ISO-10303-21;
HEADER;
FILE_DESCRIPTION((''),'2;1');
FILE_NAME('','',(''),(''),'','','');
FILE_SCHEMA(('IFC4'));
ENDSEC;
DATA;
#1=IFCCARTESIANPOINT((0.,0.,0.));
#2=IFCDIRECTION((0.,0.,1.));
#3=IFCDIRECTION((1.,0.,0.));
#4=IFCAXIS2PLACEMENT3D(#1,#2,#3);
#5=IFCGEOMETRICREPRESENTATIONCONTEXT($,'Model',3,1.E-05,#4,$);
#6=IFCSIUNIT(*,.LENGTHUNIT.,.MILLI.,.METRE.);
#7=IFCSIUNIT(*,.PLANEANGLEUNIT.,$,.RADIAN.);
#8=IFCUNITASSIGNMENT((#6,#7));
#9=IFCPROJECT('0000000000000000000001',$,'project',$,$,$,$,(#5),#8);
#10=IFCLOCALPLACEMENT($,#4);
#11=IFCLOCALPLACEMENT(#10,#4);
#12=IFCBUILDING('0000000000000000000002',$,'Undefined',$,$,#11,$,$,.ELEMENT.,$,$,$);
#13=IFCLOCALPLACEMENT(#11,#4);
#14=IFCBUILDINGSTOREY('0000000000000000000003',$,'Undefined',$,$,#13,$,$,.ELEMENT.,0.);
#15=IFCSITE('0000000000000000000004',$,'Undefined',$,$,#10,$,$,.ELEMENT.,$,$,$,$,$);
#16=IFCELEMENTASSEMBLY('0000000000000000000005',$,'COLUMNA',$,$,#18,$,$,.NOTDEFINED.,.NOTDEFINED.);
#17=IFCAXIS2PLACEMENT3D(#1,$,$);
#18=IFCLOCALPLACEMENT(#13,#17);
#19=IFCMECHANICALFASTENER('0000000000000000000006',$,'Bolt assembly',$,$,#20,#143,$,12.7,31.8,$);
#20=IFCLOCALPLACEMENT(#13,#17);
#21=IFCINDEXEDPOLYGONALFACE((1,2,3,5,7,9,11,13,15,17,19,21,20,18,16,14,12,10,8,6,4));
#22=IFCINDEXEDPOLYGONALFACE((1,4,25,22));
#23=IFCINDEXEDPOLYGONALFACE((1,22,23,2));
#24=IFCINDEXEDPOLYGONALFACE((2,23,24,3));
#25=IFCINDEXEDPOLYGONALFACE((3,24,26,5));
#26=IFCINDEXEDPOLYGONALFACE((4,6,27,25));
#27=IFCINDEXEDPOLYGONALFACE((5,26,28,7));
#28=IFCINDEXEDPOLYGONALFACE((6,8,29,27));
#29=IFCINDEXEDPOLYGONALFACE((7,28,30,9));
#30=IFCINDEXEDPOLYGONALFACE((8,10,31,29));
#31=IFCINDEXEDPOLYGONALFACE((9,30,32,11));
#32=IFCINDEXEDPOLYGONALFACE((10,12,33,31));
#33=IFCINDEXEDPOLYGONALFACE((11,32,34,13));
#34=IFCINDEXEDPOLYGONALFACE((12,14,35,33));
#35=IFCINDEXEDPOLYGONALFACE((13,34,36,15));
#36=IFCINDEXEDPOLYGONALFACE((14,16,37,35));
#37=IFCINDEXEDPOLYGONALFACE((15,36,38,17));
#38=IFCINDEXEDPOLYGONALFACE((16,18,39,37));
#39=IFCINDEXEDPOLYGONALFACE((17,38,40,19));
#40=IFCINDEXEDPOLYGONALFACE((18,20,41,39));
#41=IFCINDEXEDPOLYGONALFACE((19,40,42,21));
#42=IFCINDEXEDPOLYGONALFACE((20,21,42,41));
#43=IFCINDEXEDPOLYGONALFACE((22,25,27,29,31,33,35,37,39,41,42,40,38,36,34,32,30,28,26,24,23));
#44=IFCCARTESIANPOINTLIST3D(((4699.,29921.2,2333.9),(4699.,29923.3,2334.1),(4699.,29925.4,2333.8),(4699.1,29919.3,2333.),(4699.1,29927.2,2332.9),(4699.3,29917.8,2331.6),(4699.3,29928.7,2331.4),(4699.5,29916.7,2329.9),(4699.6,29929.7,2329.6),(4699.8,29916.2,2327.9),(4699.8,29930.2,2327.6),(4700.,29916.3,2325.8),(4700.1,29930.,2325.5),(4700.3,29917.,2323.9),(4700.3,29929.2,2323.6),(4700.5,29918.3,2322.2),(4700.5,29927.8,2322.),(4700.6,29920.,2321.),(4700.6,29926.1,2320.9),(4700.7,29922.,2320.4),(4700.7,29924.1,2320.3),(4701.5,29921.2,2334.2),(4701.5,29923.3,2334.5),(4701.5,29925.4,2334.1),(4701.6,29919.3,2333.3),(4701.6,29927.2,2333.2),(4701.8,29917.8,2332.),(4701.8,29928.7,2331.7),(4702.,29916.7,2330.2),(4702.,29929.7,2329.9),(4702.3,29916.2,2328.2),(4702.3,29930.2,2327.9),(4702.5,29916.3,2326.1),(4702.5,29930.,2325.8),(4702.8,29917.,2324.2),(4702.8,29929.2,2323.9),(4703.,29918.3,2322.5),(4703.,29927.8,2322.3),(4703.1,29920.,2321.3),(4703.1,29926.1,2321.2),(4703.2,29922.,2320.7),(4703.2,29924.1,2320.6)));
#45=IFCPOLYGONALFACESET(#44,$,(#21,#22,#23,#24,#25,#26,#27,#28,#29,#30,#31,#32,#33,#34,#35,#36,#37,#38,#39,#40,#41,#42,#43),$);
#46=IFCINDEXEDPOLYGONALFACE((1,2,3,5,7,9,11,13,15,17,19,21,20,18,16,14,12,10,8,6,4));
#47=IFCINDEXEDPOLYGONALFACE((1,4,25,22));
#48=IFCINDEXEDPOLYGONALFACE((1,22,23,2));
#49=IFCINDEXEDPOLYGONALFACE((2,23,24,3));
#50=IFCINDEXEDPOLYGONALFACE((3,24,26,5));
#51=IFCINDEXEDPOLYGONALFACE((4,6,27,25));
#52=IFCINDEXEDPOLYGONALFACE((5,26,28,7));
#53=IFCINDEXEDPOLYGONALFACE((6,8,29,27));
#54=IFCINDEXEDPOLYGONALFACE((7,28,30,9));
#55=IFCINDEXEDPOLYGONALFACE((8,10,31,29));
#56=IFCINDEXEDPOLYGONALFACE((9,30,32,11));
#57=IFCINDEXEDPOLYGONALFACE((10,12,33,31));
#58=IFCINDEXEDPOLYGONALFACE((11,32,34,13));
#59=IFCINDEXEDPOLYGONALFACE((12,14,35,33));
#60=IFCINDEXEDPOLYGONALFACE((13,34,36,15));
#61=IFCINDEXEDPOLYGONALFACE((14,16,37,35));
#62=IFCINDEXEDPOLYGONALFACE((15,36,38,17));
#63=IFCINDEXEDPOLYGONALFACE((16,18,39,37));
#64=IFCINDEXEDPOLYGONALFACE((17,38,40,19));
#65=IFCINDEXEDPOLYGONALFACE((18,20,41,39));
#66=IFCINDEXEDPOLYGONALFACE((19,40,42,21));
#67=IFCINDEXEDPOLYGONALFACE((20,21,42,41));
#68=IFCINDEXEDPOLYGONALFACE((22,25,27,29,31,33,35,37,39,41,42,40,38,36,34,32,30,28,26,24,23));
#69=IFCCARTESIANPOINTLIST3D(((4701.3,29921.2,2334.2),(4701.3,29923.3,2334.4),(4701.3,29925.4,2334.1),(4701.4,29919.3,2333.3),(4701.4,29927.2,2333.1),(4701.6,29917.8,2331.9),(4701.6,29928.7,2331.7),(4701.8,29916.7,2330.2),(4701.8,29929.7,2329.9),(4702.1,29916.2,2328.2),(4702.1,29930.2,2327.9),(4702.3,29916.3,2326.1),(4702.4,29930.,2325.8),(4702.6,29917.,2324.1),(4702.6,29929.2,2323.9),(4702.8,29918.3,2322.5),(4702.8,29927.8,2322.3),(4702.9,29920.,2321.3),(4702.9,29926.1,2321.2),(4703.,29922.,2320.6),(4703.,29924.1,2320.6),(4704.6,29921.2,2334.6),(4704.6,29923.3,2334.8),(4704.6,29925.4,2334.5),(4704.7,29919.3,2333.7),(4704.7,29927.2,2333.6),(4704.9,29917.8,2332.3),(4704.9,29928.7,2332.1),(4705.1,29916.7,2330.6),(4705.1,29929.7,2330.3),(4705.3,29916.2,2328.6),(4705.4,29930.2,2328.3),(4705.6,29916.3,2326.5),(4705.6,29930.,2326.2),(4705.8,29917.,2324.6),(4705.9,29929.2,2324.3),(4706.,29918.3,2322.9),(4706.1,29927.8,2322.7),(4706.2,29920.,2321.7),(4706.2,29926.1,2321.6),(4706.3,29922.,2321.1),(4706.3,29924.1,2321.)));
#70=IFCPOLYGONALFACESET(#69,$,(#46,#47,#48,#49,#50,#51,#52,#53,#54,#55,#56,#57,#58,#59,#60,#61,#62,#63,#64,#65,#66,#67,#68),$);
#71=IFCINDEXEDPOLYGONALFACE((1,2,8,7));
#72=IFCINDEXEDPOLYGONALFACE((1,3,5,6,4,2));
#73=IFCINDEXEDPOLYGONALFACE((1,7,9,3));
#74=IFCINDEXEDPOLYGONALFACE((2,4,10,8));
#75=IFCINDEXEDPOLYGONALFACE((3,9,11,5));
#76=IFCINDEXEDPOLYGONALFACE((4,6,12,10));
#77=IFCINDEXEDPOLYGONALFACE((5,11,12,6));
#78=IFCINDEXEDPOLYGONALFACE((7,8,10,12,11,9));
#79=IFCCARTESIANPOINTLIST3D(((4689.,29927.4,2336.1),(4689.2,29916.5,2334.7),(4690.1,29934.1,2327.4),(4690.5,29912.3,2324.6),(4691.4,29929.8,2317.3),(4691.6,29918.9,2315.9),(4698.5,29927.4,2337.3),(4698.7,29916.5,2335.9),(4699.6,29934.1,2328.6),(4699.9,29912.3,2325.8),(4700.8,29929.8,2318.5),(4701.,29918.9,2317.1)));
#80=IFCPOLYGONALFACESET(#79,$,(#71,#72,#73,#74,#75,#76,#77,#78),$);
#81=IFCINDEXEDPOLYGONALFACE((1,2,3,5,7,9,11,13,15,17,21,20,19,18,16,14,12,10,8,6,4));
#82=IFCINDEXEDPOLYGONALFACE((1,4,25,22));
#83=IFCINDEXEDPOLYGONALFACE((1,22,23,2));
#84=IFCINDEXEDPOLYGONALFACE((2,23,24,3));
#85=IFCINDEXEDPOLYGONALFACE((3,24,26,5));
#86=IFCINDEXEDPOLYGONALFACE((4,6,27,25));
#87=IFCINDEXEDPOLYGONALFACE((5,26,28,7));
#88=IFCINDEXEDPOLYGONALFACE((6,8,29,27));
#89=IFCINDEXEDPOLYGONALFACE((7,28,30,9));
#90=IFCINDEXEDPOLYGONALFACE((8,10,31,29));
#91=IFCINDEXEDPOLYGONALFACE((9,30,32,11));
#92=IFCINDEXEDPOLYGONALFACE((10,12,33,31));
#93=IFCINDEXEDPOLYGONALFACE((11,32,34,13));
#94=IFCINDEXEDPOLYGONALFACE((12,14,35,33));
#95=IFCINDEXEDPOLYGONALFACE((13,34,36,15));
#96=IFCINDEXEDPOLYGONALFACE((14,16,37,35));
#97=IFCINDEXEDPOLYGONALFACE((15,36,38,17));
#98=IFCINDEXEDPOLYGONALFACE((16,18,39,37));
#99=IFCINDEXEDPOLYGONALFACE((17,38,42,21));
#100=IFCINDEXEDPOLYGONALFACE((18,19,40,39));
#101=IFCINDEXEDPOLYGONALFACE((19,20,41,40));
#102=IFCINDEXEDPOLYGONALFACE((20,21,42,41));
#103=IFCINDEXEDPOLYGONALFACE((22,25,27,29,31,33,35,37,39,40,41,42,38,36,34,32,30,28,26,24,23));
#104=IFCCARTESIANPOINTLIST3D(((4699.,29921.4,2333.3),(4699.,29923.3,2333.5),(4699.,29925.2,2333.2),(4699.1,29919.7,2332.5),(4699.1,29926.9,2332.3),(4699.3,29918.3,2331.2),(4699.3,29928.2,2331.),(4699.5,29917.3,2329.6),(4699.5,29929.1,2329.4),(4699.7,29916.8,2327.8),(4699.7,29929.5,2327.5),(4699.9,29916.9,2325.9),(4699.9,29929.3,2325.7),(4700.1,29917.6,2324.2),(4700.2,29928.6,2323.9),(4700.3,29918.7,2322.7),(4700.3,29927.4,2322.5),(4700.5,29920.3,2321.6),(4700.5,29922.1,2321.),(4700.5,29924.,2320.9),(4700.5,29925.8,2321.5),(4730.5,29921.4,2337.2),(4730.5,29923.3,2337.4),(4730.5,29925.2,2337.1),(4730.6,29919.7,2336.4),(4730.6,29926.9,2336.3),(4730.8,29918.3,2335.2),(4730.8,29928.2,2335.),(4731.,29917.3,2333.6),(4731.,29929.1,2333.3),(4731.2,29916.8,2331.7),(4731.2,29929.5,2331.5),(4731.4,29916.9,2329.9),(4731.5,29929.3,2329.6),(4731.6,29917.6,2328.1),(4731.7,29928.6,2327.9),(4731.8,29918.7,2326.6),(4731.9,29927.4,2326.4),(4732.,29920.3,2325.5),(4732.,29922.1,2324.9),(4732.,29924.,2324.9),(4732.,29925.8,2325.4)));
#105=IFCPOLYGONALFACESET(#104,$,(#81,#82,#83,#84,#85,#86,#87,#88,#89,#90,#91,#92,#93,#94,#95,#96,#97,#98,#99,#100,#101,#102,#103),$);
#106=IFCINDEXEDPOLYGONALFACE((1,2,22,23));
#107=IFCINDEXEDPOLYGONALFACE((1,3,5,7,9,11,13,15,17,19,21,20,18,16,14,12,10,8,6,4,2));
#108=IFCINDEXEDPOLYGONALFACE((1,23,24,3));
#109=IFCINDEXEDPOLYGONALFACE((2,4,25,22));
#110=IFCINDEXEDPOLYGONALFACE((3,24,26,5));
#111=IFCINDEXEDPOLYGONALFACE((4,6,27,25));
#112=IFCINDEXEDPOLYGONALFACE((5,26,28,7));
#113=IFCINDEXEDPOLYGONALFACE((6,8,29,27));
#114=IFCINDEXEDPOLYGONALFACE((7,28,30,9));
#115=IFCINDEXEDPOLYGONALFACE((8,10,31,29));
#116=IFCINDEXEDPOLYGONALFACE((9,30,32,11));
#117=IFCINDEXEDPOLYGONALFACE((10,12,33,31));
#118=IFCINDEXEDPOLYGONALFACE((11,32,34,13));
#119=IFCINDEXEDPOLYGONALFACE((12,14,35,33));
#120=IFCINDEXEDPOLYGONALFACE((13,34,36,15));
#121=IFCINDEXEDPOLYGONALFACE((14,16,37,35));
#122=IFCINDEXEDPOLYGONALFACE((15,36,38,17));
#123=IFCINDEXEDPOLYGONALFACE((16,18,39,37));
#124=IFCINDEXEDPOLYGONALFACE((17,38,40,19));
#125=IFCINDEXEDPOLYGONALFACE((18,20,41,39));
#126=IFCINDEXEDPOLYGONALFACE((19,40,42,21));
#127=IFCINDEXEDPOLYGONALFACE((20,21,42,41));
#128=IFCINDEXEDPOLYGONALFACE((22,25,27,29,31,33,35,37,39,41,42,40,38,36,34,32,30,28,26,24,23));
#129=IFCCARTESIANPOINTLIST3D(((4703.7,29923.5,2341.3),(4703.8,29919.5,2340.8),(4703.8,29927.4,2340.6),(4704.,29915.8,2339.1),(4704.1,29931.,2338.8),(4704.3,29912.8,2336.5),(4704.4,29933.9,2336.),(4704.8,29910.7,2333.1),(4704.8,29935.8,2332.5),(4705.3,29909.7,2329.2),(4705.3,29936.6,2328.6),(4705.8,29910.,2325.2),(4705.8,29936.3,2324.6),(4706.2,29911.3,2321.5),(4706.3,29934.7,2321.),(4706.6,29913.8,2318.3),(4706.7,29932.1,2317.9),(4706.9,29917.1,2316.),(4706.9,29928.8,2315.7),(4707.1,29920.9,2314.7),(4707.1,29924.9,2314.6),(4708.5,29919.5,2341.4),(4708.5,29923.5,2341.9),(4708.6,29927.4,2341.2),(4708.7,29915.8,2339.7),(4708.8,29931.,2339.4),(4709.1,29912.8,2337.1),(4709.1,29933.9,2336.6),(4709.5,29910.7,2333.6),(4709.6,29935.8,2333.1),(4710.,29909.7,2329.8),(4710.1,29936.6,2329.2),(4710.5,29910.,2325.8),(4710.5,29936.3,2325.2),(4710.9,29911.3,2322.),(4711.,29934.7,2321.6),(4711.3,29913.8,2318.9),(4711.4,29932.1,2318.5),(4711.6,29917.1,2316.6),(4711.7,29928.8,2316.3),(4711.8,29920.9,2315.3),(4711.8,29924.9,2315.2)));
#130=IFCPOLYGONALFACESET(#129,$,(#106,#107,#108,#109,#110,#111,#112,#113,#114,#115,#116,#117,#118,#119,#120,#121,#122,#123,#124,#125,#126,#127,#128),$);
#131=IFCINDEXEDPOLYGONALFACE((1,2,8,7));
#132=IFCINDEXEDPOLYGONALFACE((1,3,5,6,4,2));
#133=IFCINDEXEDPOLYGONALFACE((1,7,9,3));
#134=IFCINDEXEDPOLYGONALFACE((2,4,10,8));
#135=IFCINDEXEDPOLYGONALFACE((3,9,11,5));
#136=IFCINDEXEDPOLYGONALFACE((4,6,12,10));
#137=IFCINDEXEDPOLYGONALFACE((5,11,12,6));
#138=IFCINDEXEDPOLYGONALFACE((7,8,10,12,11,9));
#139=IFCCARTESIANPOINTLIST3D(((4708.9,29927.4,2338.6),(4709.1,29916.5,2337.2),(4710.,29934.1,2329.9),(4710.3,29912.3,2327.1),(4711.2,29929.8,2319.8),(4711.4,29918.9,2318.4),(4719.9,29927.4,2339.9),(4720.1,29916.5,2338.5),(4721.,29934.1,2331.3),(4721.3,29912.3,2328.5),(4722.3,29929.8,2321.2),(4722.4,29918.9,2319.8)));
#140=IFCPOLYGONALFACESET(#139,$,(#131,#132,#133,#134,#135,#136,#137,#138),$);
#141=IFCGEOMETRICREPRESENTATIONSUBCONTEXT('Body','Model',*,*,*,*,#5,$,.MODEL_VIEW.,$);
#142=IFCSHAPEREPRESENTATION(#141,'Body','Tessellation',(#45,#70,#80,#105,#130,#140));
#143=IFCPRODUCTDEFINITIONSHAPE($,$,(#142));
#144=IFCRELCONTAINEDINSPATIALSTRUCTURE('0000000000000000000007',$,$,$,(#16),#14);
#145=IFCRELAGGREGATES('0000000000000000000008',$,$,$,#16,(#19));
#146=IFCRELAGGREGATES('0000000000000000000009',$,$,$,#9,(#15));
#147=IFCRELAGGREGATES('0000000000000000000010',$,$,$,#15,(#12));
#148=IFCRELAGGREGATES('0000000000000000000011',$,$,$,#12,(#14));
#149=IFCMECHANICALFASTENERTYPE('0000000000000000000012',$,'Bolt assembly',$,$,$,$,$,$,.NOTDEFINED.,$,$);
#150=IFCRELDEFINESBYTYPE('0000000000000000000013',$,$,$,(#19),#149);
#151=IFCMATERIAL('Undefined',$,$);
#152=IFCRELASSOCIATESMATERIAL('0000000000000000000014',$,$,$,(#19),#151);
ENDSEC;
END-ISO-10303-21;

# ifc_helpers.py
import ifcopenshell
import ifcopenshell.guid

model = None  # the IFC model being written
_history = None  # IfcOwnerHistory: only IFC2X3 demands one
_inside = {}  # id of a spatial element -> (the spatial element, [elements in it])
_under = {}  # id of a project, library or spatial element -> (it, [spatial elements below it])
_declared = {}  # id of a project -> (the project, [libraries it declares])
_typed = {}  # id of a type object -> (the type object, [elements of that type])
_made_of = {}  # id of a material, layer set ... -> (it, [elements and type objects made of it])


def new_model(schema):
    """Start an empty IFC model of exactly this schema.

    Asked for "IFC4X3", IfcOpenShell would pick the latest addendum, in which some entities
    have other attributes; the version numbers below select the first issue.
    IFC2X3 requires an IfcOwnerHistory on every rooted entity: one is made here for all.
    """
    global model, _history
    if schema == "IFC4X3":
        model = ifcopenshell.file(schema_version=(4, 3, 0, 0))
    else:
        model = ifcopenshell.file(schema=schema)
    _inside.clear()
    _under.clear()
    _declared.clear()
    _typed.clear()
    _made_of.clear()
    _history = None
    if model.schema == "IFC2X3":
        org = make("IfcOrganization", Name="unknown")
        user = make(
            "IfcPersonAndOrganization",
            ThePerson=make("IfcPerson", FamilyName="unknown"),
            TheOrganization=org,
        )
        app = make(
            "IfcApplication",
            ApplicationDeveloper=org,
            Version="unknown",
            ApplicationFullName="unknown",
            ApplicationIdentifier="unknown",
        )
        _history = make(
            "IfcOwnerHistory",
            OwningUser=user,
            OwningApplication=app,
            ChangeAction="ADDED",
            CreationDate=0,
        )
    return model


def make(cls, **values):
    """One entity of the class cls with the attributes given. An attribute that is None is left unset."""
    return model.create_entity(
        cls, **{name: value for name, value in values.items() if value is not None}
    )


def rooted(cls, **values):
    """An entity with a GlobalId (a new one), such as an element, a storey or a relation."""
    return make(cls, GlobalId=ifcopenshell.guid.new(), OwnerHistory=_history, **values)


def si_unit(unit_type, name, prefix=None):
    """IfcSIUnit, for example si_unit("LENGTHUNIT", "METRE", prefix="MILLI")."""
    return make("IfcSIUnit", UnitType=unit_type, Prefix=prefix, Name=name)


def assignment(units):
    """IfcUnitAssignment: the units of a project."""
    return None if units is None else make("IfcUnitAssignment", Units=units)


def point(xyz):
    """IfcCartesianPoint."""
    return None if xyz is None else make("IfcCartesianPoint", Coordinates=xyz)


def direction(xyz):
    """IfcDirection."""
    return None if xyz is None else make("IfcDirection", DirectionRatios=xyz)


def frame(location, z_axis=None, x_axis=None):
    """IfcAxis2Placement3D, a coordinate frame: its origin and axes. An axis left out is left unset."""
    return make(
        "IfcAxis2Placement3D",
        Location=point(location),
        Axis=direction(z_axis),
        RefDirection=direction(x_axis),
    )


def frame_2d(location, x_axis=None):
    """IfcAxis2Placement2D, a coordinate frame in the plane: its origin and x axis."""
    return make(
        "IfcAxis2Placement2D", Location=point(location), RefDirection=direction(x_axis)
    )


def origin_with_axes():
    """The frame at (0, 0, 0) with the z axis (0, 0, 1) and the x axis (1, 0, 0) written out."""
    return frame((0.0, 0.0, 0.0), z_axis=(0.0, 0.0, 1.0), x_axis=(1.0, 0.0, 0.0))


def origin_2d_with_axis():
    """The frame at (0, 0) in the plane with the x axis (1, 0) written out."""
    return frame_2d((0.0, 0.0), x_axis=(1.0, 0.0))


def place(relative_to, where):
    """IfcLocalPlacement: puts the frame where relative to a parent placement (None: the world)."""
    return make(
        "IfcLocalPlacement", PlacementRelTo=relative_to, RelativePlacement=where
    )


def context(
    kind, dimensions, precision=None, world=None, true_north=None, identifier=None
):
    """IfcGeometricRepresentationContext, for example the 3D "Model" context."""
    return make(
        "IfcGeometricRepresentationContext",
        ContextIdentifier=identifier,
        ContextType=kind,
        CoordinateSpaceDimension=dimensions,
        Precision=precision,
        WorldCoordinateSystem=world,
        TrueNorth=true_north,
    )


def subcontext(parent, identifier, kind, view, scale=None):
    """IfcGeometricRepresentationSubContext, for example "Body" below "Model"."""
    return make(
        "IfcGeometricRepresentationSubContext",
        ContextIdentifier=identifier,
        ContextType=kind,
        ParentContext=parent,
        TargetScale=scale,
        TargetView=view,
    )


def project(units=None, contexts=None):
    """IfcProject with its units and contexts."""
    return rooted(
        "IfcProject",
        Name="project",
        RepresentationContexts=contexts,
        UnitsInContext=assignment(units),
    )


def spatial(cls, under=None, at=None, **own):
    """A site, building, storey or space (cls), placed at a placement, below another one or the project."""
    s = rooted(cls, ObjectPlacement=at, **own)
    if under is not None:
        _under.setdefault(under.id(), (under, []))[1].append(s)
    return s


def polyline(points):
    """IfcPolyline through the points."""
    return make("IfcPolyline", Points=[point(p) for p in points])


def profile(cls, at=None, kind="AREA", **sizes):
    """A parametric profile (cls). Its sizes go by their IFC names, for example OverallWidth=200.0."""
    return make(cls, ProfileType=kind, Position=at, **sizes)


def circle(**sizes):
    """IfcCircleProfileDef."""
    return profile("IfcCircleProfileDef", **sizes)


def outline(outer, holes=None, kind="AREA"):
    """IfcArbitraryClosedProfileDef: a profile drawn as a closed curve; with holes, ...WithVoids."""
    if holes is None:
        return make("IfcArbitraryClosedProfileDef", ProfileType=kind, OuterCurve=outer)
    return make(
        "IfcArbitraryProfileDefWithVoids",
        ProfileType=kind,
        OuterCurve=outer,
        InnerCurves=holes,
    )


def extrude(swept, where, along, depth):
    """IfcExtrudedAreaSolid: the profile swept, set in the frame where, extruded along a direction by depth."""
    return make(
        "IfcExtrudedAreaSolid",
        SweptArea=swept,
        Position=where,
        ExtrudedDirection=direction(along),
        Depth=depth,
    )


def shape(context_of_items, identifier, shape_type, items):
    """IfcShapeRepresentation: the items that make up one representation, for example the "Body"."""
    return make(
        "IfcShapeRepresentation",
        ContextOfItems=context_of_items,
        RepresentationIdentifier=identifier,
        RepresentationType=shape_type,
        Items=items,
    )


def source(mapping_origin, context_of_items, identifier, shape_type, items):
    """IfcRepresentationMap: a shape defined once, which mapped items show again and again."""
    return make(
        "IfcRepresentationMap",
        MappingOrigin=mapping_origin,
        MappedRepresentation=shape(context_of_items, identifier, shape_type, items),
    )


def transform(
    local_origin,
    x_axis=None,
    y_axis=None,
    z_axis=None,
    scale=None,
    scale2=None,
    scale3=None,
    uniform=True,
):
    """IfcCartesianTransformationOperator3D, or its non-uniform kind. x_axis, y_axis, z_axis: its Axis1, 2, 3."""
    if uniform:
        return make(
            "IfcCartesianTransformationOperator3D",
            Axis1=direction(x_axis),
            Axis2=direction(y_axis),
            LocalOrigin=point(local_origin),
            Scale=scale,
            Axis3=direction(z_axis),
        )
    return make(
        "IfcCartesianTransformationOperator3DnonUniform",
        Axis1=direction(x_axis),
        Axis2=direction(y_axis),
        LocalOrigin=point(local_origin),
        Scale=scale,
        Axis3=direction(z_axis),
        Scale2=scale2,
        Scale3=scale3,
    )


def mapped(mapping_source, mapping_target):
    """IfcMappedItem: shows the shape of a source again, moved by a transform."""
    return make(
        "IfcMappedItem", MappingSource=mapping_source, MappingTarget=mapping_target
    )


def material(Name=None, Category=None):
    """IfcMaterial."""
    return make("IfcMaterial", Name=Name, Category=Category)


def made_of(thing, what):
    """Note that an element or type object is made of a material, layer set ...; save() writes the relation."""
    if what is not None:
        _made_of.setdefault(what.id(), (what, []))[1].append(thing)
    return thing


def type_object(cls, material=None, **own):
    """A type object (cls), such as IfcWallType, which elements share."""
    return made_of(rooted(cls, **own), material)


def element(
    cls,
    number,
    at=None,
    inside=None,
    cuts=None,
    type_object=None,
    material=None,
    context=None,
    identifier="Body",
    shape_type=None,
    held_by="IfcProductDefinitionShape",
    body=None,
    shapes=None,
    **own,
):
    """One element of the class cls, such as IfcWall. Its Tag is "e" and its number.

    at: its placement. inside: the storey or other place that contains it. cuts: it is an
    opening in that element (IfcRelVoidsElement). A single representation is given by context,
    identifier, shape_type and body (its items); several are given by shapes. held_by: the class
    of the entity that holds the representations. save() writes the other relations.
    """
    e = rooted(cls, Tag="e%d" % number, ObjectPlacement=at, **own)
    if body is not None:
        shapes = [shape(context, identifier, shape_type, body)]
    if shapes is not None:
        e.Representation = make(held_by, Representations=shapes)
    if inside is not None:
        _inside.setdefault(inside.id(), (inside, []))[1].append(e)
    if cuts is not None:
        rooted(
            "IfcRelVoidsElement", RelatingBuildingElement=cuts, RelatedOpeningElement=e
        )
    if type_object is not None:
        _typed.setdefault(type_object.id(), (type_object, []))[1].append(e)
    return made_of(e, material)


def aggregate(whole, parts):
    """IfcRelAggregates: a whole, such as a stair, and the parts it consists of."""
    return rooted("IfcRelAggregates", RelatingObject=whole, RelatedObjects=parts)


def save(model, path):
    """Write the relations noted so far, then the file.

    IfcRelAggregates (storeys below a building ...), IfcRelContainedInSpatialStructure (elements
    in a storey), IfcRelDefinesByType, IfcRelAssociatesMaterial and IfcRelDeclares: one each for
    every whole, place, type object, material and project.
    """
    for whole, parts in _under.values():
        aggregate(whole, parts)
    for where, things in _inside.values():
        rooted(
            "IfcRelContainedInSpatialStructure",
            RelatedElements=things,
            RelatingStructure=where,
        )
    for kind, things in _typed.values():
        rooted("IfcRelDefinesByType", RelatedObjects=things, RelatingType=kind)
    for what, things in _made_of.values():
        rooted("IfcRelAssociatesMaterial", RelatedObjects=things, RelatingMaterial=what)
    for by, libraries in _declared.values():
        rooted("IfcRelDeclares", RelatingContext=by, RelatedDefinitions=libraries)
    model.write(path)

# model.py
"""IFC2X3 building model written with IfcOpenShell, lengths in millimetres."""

from ifc_helpers import new_model, si_unit, frame, origin_with_axes, origin_2d_with_axis, place, context, subcontext, project, spatial, polyline, circle, outline, extrude, source, transform, mapped, material, type_object, element, aggregate, save


model = new_model("IFC2X3")

# Units and contexts
model_context = context("Model", 3, precision=1e-05, world=origin_with_axes())
body_context = subcontext(model_context, "Body", "Model", "MODEL_VIEW")
ifc_project = project(units=[si_unit("LENGTHUNIT", "METRE", prefix="MILLI"), si_unit("PLANEANGLEUNIT", "RADIAN")], contexts=[model_context])

# Site, building, storey
site_placement = place(None, origin_with_axes())
site = spatial("IfcSite", under=ifc_project, at=site_placement, Name="Undefined", CompositionType="ELEMENT")
building_placement = place(site_placement, origin_with_axes())
building = spatial("IfcBuilding", under=site, at=building_placement, Name="Undefined", CompositionType="ELEMENT")
storey_placement = place(building_placement, origin_with_axes())
storey = spatial("IfcBuildingStorey", under=building, at=storey_placement, Name="Undefined", CompositionType="ELEMENT", Elevation=0.0)

# Element assembly
assembly_1_placement = place(storey_placement, origin_with_axes())
assembly_1 = element("IfcElementAssembly", 1, at=assembly_1_placement, inside=storey, Name="COLUMNA", AssemblyPlace="NOTDEFINED", PredefinedType="NOTDEFINED")

# Shared definitions
ifc_material_1 = material(Name="Undefined")
mechanical_fastener_type = type_object("IfcMechanicalFastenerType", Name="Bolt assembly")

# Mechanical fastener
shared_shape_1 = source(origin_with_axes(), body_context, "Body", "SweptSolid", [
    extrude(circle(Radius=7.0, at=origin_2d_with_axis()), frame((0.0, -2.4, 0.0), z_axis=(0.0, 1.0, 0.0), x_axis=(1.0, 0.0, 0.0)), (0.0, 0.0, 1.0), 2.5),
    extrude(circle(Radius=7.0, at=origin_2d_with_axis()), frame((0.0, -0.1, 0.0), z_axis=(0.0, 1.0, 0.0), x_axis=(1.0, 0.0, 0.0)), (0.0, 0.0, 1.0), 3.3),
    extrude(outline(polyline([(9.5, -5.5), (9.5, 5.5), (0.0, 11.0), (-9.5, 5.5), (-9.5, -5.5), (0.0, -11.0), (9.5, -5.5)])), frame((0.0, -12.0, 0.0), z_axis=(0.0, 1.0, 0.0), x_axis=(1.0, 0.0, 0.0)), (0.0, 0.0, 1.0), 9.5),
    extrude(circle(Radius=6.3, at=origin_2d_with_axis()), frame((0.0, -2.5, 0.0), z_axis=(0.0, 1.0, 0.0), x_axis=(1.0, 0.0, 0.0)), (0.0, 0.0, 1.0), 31.8),
    extrude(circle(Radius=13.5, at=origin_2d_with_axis()), frame((0.0, 3.2, 0.0), z_axis=(0.0, 1.0, 0.0), x_axis=(1.0, 0.0, 0.0)), (0.0, 0.0, 1.0), 4.8),
    extrude(outline(polyline([(9.5, -5.5), (9.5, 5.5), (0.0, 11.0), (-9.5, 5.5), (-9.5, -5.5), (0.0, -11.0), (9.5, -5.5)])), frame((0.0, 8.0, 0.0), z_axis=(0.0, 1.0, 0.0), x_axis=(1.0, 0.0, 0.0)), (0.0, 0.0, 1.0), 11.1),
])
mechanical_fastener_1_placement = place(assembly_1_placement, frame((4702.2, 29923.2, 2327.5), z_axis=(0.098611, 0.606774, -0.788734), x_axis=(-0.075276, 0.794875, 0.602086)))
mechanical_fastener_1 = element("IfcMechanicalFastener", 2, at=mechanical_fastener_1_placement, type_object=mechanical_fastener_type, material=ifc_material_1, Name="Bolt assembly", NominalDiameter=12.7, NominalLength=31.8, context=body_context, shape_type="MappedRepresentation", body=[
    mapped(shared_shape_1, transform((0.0, 0.0, 0.0))),
])
aggregate(assembly_1, [mechanical_fastener_1])

save(model, "model.ifc")
